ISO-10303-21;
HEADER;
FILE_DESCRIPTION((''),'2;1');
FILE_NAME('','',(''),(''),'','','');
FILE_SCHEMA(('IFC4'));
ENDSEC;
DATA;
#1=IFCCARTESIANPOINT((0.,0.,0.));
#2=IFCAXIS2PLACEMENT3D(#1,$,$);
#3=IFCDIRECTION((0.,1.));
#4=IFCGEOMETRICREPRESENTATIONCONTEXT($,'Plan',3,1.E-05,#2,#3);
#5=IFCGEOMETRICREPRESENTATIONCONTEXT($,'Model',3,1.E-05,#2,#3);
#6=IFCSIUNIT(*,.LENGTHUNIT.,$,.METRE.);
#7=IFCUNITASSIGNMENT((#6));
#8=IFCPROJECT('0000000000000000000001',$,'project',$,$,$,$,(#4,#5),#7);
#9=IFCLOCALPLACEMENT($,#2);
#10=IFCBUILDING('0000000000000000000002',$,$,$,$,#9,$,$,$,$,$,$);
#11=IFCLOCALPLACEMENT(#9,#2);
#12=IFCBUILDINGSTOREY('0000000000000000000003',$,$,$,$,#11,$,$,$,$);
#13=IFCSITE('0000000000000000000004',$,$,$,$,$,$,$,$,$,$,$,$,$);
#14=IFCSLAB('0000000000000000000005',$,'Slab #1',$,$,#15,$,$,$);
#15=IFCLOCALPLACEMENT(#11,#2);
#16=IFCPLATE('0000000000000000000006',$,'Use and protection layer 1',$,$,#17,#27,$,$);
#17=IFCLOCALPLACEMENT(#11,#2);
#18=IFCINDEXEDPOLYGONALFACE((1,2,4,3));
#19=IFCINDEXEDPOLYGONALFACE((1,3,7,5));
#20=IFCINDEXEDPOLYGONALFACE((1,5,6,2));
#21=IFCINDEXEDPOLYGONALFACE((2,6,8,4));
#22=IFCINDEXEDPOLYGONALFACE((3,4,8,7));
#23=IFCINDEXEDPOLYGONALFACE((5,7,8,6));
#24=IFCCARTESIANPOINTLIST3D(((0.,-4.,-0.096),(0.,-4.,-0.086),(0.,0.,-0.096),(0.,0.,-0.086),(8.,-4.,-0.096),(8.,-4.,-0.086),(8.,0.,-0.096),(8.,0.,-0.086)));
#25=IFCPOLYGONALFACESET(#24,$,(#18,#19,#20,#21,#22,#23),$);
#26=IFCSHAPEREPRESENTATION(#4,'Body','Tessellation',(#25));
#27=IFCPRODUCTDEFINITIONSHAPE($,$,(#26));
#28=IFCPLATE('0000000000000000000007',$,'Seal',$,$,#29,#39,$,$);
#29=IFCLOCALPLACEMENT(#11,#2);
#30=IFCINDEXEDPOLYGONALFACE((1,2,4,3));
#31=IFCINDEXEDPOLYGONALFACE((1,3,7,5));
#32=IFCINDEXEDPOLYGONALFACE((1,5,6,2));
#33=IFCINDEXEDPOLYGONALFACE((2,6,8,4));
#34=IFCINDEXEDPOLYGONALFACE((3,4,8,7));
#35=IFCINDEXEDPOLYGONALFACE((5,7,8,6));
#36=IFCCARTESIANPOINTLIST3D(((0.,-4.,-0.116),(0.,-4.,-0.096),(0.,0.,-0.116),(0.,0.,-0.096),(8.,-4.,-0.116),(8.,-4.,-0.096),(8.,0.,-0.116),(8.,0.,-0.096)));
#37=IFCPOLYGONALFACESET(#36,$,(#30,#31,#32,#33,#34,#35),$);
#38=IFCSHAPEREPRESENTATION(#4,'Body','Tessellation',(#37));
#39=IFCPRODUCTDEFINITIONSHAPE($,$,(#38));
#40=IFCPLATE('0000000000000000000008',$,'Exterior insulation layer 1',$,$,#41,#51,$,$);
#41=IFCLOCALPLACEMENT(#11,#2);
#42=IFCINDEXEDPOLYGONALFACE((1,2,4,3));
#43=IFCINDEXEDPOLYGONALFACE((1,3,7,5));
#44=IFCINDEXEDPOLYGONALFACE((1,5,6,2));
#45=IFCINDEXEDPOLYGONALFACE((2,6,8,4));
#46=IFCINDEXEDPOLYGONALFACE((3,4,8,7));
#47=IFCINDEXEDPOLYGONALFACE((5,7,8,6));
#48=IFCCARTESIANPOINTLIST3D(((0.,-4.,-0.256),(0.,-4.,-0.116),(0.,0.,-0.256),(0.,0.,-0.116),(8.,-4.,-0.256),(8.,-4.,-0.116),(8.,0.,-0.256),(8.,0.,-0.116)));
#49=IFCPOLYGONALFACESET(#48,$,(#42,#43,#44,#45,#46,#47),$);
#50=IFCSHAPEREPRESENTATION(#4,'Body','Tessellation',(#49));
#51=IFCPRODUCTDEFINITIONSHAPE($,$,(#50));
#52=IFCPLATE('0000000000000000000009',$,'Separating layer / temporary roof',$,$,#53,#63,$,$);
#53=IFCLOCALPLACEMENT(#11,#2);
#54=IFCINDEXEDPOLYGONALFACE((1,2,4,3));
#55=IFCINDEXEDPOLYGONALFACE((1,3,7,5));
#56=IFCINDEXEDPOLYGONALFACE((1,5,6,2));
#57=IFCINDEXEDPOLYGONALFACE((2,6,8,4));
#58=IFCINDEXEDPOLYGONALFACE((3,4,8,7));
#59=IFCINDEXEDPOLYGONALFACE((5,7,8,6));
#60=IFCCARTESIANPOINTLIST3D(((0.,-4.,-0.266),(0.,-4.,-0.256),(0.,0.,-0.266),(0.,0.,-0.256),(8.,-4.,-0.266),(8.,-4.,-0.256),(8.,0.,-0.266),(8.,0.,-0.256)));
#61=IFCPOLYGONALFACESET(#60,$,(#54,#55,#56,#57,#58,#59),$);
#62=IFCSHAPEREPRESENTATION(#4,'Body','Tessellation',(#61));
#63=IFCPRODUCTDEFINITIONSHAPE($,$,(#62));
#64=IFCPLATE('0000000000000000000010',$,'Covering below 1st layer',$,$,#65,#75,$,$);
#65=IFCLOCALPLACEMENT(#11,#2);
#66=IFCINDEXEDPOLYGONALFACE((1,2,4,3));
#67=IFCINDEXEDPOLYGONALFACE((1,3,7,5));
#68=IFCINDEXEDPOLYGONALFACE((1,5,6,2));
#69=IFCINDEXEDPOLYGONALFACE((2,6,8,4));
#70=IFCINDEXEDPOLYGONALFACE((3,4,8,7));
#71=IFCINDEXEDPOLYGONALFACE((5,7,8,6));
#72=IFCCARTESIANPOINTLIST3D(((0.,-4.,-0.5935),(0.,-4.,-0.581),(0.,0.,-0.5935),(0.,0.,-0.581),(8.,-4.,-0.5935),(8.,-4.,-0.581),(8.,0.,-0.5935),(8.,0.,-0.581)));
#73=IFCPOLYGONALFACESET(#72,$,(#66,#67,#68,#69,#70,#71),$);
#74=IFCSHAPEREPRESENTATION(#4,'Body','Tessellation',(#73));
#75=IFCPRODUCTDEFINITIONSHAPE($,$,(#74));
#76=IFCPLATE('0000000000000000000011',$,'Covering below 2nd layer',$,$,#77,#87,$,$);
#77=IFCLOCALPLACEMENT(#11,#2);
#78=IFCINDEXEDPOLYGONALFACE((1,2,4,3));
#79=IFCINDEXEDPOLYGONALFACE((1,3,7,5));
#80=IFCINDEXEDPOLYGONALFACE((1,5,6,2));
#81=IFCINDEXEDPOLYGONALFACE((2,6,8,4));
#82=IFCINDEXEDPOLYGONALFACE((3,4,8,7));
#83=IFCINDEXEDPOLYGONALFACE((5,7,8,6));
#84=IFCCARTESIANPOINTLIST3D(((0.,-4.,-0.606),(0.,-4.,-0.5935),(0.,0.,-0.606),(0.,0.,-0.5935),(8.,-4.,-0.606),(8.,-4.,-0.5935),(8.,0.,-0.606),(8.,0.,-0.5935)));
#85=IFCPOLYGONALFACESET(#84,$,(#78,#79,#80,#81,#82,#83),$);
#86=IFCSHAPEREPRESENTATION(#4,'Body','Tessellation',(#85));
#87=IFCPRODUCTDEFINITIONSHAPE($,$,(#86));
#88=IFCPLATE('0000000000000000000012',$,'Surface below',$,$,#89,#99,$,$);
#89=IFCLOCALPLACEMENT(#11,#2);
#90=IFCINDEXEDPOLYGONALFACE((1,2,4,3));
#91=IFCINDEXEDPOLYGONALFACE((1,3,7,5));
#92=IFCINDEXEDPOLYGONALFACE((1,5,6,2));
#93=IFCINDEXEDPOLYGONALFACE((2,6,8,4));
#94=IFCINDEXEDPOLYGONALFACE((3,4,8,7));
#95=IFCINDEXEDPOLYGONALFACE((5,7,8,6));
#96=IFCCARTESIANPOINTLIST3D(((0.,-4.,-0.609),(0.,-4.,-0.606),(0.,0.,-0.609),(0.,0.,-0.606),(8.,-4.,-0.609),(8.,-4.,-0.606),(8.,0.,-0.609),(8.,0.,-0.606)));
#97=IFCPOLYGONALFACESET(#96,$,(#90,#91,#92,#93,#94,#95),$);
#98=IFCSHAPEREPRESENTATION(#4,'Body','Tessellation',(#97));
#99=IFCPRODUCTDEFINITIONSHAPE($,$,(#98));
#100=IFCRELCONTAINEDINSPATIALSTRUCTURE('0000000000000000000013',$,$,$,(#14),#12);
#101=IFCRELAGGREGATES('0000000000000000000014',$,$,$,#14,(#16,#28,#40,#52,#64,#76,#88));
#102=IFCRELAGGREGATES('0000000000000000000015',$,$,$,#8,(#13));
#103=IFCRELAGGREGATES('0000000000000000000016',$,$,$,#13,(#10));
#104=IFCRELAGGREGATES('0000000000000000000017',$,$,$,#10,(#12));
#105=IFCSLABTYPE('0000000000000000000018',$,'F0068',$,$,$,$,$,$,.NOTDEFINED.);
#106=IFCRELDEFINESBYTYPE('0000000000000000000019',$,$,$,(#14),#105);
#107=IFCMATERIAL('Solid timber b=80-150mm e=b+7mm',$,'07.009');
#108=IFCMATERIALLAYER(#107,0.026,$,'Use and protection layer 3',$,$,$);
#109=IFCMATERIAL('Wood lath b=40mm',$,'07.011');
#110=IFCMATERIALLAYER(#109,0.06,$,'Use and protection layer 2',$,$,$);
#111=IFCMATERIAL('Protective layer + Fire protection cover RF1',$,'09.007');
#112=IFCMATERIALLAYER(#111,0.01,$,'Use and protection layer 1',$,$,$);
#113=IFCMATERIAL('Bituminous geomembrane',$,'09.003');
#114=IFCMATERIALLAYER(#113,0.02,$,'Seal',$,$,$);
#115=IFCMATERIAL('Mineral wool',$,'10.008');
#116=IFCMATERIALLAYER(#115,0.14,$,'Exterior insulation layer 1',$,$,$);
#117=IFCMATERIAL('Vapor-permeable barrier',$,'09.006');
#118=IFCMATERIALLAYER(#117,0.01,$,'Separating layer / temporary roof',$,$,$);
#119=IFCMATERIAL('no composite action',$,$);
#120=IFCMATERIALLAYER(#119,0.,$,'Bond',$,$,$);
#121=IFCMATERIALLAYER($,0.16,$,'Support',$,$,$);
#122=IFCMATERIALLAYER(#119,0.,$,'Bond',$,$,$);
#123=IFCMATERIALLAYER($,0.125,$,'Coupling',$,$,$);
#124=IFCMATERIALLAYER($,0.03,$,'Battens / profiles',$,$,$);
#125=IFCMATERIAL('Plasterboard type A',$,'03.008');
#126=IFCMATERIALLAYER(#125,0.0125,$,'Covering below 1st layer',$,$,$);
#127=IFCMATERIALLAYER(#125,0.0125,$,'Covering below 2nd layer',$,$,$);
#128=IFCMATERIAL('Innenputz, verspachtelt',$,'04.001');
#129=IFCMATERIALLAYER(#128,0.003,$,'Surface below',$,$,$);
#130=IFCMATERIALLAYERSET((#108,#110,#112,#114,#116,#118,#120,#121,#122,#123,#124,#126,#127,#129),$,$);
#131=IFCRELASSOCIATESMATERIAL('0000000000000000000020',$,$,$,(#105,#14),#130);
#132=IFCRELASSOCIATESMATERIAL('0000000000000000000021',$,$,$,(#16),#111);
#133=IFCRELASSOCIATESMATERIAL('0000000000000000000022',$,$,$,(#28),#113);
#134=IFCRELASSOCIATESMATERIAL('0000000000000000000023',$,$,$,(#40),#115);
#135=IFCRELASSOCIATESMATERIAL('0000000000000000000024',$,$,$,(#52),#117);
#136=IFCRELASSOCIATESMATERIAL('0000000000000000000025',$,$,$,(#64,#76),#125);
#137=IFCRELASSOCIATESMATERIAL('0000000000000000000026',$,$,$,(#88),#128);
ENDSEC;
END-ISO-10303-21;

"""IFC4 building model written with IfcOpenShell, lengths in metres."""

from ifc_helpers import new_model, si_unit, direction, frame, frame_2d, origin, place, context, project, spatial, rectangle, extrude, material, layer, layer_set, type_object, element, aggregate, save


model = new_model("IFC4")

# Units and contexts
plan_context = context("Plan", 3, precision=1e-05, world=origin(), true_north=direction((0.0, 1.0)))
model_context = context("Model", 3, precision=1e-05, world=origin(), true_north=direction((0.0, 1.0)))
ifc_project = project(units=[si_unit("LENGTHUNIT", "METRE")], contexts=[plan_context, model_context])

# Site, building, storey
site = spatial("IfcSite", under=ifc_project)
building_placement = place(None, origin())
building = spatial("IfcBuilding", under=site, at=building_placement)
storey_placement = place(building_placement, origin())
storey = spatial("IfcBuildingStorey", under=building, at=storey_placement)

# Slab, plates
ifc_material_1 = material(Name="Solid timber b=80-150mm e=b+7mm", Category="07.009")
ifc_layer_1 = layer(ifc_material_1, 0.026, Name="Use and protection layer 3")
ifc_material_2 = material(Name="Wood lath b=40mm", Category="07.011")
ifc_layer_2 = layer(ifc_material_2, 0.06, Name="Use and protection layer 2")
ifc_material_3 = material(Name="Protective layer + Fire protection cover RF1", Category="09.007")
ifc_layer_3 = layer(ifc_material_3, 0.01, Name="Use and protection layer 1")
ifc_material_4 = material(Name="Bituminous geomembrane", Category="09.003")
ifc_layer_4 = layer(ifc_material_4, 0.02, Name="Seal")
ifc_material_5 = material(Name="Mineral wool", Category="10.008")
ifc_layer_5 = layer(ifc_material_5, 0.14, Name="Exterior insulation layer 1")
ifc_material_6 = material(Name="Vapor-permeable barrier", Category="09.006")
ifc_layer_6 = layer(ifc_material_6, 0.01, Name="Separating layer / temporary roof")
ifc_material_7 = material(Name="no composite action")
ifc_layer_7 = layer(ifc_material_7, 0.0, Name="Bond")
ifc_layer_8 = layer(None, 0.16, Name="Support")
ifc_layer_9 = layer(ifc_material_7, 0.0, Name="Bond")
ifc_layer_10 = layer(None, 0.125, Name="Coupling")
ifc_layer_11 = layer(None, 0.03, Name="Battens / profiles")
ifc_material_8 = material(Name="Plasterboard type A", Category="03.008")
ifc_layer_12 = layer(ifc_material_8, 0.0125, Name="Covering below 1st layer")
ifc_layer_13 = layer(ifc_material_8, 0.0125, Name="Covering below 2nd layer")
ifc_material_9 = material(Name="Innenputz, verspachtelt", Category="04.001")
ifc_layer_14 = layer(ifc_material_9, 0.003, Name="Surface below")
ifc_layer_set = layer_set([ifc_layer_1, ifc_layer_2, ifc_layer_3, ifc_layer_4, ifc_layer_5, ifc_layer_6, ifc_layer_7, ifc_layer_8, ifc_layer_9, ifc_layer_10, ifc_layer_11, ifc_layer_12, ifc_layer_13, ifc_layer_14])
slab_type = type_object("IfcSlabType", Name="F0068", PredefinedType="NOTDEFINED", material=ifc_layer_set)
slab_placement = place(None, frame((0.0, 0.0, 0.0), z_axis=(0.0, 0.0, -1.0), x_axis=(1.0, 0.0, 0.0)))
slab = element("IfcSlab", 1, at=slab_placement, inside=storey, type_object=slab_type, material=ifc_layer_set, Name="Slab #1")
plate_1_placement = place(slab_placement, origin())
plate_1 = element("IfcPlate", 2, at=plate_1_placement, material=ifc_material_3, Name="Use and protection layer 1", context=plan_context, shape_type="SweptSolid", body=[
    extrude(rectangle(XDim=8.0, YDim=4.0, at=frame_2d((4.0, 2.0), x_axis=(1.0, 0.0))), frame((0.0, 0.0, 0.086), z_axis=(0.0, 0.0, 1.0), x_axis=(1.0, 0.0, 0.0)), (0.0, 0.0, 1.0), 0.01),
])
plate_2_placement = place(slab_placement, origin())
plate_2 = element("IfcPlate", 3, at=plate_2_placement, material=ifc_material_4, Name="Seal", context=plan_context, shape_type="SweptSolid", body=[
    extrude(rectangle(XDim=8.0, YDim=4.0, at=frame_2d((4.0, 2.0), x_axis=(1.0, 0.0))), frame((0.0, 0.0, 0.096), z_axis=(0.0, 0.0, 1.0), x_axis=(1.0, 0.0, 0.0)), (0.0, 0.0, 1.0), 0.02),
])
plate_3_placement = place(slab_placement, origin())
plate_3 = element("IfcPlate", 4, at=plate_3_placement, material=ifc_material_5, Name="Exterior insulation layer 1", context=plan_context, shape_type="SweptSolid", body=[
    extrude(rectangle(XDim=8.0, YDim=4.0, at=frame_2d((4.0, 2.0), x_axis=(1.0, 0.0))), frame((0.0, 0.0, 0.116), z_axis=(0.0, 0.0, 1.0), x_axis=(1.0, 0.0, 0.0)), (0.0, 0.0, 1.0), 0.14),
])
plate_4_placement = place(slab_placement, origin())
plate_4 = element("IfcPlate", 5, at=plate_4_placement, material=ifc_material_6, Name="Separating layer / temporary roof", context=plan_context, shape_type="SweptSolid", body=[
    extrude(rectangle(XDim=8.0, YDim=4.0, at=frame_2d((4.0, 2.0), x_axis=(1.0, 0.0))), frame((0.0, 0.0, 0.256), z_axis=(0.0, 0.0, 1.0), x_axis=(1.0, 0.0, 0.0)), (0.0, 0.0, 1.0), 0.01),
])
plate_5_placement = place(slab_placement, origin())
plate_5 = element("IfcPlate", 6, at=plate_5_placement, material=ifc_material_8, Name="Covering below 1st layer", context=plan_context, shape_type="SweptSolid", body=[
    extrude(rectangle(XDim=8.0, YDim=4.0, at=frame_2d((4.0, 2.0), x_axis=(1.0, 0.0))), frame((0.0, 0.0, 0.581), z_axis=(0.0, 0.0, 1.0), x_axis=(1.0, 0.0, 0.0)), (0.0, 0.0, 1.0), 0.0125),
])
plate_6_placement = place(slab_placement, origin())
plate_6 = element("IfcPlate", 7, at=plate_6_placement, material=ifc_material_8, Name="Covering below 2nd layer", context=plan_context, shape_type="SweptSolid", body=[
    extrude(rectangle(XDim=8.0, YDim=4.0, at=frame_2d((4.0, 2.0), x_axis=(1.0, 0.0))), frame((0.0, 0.0, 0.5935), z_axis=(0.0, 0.0, 1.0), x_axis=(1.0, 0.0, 0.0)), (0.0, 0.0, 1.0), 0.0125),
])
plate_7_placement = place(slab_placement, origin())
plate_7 = element("IfcPlate", 8, at=plate_7_placement, material=ifc_material_9, Name="Surface below", context=plan_context, shape_type="SweptSolid", body=[
    extrude(rectangle(XDim=8.0, YDim=4.0, at=frame_2d((4.0, 2.0), x_axis=(1.0, 0.0))), frame((0.0, 0.0, 0.606), z_axis=(0.0, 0.0, 1.0), x_axis=(1.0, 0.0, 0.0)), (0.0, 0.0, 1.0), 0.003),
])
aggregate(slab, [plate_1, plate_2, plate_3, plate_4, plate_5, plate_6, plate_7])

save(model, "model.ifc")
